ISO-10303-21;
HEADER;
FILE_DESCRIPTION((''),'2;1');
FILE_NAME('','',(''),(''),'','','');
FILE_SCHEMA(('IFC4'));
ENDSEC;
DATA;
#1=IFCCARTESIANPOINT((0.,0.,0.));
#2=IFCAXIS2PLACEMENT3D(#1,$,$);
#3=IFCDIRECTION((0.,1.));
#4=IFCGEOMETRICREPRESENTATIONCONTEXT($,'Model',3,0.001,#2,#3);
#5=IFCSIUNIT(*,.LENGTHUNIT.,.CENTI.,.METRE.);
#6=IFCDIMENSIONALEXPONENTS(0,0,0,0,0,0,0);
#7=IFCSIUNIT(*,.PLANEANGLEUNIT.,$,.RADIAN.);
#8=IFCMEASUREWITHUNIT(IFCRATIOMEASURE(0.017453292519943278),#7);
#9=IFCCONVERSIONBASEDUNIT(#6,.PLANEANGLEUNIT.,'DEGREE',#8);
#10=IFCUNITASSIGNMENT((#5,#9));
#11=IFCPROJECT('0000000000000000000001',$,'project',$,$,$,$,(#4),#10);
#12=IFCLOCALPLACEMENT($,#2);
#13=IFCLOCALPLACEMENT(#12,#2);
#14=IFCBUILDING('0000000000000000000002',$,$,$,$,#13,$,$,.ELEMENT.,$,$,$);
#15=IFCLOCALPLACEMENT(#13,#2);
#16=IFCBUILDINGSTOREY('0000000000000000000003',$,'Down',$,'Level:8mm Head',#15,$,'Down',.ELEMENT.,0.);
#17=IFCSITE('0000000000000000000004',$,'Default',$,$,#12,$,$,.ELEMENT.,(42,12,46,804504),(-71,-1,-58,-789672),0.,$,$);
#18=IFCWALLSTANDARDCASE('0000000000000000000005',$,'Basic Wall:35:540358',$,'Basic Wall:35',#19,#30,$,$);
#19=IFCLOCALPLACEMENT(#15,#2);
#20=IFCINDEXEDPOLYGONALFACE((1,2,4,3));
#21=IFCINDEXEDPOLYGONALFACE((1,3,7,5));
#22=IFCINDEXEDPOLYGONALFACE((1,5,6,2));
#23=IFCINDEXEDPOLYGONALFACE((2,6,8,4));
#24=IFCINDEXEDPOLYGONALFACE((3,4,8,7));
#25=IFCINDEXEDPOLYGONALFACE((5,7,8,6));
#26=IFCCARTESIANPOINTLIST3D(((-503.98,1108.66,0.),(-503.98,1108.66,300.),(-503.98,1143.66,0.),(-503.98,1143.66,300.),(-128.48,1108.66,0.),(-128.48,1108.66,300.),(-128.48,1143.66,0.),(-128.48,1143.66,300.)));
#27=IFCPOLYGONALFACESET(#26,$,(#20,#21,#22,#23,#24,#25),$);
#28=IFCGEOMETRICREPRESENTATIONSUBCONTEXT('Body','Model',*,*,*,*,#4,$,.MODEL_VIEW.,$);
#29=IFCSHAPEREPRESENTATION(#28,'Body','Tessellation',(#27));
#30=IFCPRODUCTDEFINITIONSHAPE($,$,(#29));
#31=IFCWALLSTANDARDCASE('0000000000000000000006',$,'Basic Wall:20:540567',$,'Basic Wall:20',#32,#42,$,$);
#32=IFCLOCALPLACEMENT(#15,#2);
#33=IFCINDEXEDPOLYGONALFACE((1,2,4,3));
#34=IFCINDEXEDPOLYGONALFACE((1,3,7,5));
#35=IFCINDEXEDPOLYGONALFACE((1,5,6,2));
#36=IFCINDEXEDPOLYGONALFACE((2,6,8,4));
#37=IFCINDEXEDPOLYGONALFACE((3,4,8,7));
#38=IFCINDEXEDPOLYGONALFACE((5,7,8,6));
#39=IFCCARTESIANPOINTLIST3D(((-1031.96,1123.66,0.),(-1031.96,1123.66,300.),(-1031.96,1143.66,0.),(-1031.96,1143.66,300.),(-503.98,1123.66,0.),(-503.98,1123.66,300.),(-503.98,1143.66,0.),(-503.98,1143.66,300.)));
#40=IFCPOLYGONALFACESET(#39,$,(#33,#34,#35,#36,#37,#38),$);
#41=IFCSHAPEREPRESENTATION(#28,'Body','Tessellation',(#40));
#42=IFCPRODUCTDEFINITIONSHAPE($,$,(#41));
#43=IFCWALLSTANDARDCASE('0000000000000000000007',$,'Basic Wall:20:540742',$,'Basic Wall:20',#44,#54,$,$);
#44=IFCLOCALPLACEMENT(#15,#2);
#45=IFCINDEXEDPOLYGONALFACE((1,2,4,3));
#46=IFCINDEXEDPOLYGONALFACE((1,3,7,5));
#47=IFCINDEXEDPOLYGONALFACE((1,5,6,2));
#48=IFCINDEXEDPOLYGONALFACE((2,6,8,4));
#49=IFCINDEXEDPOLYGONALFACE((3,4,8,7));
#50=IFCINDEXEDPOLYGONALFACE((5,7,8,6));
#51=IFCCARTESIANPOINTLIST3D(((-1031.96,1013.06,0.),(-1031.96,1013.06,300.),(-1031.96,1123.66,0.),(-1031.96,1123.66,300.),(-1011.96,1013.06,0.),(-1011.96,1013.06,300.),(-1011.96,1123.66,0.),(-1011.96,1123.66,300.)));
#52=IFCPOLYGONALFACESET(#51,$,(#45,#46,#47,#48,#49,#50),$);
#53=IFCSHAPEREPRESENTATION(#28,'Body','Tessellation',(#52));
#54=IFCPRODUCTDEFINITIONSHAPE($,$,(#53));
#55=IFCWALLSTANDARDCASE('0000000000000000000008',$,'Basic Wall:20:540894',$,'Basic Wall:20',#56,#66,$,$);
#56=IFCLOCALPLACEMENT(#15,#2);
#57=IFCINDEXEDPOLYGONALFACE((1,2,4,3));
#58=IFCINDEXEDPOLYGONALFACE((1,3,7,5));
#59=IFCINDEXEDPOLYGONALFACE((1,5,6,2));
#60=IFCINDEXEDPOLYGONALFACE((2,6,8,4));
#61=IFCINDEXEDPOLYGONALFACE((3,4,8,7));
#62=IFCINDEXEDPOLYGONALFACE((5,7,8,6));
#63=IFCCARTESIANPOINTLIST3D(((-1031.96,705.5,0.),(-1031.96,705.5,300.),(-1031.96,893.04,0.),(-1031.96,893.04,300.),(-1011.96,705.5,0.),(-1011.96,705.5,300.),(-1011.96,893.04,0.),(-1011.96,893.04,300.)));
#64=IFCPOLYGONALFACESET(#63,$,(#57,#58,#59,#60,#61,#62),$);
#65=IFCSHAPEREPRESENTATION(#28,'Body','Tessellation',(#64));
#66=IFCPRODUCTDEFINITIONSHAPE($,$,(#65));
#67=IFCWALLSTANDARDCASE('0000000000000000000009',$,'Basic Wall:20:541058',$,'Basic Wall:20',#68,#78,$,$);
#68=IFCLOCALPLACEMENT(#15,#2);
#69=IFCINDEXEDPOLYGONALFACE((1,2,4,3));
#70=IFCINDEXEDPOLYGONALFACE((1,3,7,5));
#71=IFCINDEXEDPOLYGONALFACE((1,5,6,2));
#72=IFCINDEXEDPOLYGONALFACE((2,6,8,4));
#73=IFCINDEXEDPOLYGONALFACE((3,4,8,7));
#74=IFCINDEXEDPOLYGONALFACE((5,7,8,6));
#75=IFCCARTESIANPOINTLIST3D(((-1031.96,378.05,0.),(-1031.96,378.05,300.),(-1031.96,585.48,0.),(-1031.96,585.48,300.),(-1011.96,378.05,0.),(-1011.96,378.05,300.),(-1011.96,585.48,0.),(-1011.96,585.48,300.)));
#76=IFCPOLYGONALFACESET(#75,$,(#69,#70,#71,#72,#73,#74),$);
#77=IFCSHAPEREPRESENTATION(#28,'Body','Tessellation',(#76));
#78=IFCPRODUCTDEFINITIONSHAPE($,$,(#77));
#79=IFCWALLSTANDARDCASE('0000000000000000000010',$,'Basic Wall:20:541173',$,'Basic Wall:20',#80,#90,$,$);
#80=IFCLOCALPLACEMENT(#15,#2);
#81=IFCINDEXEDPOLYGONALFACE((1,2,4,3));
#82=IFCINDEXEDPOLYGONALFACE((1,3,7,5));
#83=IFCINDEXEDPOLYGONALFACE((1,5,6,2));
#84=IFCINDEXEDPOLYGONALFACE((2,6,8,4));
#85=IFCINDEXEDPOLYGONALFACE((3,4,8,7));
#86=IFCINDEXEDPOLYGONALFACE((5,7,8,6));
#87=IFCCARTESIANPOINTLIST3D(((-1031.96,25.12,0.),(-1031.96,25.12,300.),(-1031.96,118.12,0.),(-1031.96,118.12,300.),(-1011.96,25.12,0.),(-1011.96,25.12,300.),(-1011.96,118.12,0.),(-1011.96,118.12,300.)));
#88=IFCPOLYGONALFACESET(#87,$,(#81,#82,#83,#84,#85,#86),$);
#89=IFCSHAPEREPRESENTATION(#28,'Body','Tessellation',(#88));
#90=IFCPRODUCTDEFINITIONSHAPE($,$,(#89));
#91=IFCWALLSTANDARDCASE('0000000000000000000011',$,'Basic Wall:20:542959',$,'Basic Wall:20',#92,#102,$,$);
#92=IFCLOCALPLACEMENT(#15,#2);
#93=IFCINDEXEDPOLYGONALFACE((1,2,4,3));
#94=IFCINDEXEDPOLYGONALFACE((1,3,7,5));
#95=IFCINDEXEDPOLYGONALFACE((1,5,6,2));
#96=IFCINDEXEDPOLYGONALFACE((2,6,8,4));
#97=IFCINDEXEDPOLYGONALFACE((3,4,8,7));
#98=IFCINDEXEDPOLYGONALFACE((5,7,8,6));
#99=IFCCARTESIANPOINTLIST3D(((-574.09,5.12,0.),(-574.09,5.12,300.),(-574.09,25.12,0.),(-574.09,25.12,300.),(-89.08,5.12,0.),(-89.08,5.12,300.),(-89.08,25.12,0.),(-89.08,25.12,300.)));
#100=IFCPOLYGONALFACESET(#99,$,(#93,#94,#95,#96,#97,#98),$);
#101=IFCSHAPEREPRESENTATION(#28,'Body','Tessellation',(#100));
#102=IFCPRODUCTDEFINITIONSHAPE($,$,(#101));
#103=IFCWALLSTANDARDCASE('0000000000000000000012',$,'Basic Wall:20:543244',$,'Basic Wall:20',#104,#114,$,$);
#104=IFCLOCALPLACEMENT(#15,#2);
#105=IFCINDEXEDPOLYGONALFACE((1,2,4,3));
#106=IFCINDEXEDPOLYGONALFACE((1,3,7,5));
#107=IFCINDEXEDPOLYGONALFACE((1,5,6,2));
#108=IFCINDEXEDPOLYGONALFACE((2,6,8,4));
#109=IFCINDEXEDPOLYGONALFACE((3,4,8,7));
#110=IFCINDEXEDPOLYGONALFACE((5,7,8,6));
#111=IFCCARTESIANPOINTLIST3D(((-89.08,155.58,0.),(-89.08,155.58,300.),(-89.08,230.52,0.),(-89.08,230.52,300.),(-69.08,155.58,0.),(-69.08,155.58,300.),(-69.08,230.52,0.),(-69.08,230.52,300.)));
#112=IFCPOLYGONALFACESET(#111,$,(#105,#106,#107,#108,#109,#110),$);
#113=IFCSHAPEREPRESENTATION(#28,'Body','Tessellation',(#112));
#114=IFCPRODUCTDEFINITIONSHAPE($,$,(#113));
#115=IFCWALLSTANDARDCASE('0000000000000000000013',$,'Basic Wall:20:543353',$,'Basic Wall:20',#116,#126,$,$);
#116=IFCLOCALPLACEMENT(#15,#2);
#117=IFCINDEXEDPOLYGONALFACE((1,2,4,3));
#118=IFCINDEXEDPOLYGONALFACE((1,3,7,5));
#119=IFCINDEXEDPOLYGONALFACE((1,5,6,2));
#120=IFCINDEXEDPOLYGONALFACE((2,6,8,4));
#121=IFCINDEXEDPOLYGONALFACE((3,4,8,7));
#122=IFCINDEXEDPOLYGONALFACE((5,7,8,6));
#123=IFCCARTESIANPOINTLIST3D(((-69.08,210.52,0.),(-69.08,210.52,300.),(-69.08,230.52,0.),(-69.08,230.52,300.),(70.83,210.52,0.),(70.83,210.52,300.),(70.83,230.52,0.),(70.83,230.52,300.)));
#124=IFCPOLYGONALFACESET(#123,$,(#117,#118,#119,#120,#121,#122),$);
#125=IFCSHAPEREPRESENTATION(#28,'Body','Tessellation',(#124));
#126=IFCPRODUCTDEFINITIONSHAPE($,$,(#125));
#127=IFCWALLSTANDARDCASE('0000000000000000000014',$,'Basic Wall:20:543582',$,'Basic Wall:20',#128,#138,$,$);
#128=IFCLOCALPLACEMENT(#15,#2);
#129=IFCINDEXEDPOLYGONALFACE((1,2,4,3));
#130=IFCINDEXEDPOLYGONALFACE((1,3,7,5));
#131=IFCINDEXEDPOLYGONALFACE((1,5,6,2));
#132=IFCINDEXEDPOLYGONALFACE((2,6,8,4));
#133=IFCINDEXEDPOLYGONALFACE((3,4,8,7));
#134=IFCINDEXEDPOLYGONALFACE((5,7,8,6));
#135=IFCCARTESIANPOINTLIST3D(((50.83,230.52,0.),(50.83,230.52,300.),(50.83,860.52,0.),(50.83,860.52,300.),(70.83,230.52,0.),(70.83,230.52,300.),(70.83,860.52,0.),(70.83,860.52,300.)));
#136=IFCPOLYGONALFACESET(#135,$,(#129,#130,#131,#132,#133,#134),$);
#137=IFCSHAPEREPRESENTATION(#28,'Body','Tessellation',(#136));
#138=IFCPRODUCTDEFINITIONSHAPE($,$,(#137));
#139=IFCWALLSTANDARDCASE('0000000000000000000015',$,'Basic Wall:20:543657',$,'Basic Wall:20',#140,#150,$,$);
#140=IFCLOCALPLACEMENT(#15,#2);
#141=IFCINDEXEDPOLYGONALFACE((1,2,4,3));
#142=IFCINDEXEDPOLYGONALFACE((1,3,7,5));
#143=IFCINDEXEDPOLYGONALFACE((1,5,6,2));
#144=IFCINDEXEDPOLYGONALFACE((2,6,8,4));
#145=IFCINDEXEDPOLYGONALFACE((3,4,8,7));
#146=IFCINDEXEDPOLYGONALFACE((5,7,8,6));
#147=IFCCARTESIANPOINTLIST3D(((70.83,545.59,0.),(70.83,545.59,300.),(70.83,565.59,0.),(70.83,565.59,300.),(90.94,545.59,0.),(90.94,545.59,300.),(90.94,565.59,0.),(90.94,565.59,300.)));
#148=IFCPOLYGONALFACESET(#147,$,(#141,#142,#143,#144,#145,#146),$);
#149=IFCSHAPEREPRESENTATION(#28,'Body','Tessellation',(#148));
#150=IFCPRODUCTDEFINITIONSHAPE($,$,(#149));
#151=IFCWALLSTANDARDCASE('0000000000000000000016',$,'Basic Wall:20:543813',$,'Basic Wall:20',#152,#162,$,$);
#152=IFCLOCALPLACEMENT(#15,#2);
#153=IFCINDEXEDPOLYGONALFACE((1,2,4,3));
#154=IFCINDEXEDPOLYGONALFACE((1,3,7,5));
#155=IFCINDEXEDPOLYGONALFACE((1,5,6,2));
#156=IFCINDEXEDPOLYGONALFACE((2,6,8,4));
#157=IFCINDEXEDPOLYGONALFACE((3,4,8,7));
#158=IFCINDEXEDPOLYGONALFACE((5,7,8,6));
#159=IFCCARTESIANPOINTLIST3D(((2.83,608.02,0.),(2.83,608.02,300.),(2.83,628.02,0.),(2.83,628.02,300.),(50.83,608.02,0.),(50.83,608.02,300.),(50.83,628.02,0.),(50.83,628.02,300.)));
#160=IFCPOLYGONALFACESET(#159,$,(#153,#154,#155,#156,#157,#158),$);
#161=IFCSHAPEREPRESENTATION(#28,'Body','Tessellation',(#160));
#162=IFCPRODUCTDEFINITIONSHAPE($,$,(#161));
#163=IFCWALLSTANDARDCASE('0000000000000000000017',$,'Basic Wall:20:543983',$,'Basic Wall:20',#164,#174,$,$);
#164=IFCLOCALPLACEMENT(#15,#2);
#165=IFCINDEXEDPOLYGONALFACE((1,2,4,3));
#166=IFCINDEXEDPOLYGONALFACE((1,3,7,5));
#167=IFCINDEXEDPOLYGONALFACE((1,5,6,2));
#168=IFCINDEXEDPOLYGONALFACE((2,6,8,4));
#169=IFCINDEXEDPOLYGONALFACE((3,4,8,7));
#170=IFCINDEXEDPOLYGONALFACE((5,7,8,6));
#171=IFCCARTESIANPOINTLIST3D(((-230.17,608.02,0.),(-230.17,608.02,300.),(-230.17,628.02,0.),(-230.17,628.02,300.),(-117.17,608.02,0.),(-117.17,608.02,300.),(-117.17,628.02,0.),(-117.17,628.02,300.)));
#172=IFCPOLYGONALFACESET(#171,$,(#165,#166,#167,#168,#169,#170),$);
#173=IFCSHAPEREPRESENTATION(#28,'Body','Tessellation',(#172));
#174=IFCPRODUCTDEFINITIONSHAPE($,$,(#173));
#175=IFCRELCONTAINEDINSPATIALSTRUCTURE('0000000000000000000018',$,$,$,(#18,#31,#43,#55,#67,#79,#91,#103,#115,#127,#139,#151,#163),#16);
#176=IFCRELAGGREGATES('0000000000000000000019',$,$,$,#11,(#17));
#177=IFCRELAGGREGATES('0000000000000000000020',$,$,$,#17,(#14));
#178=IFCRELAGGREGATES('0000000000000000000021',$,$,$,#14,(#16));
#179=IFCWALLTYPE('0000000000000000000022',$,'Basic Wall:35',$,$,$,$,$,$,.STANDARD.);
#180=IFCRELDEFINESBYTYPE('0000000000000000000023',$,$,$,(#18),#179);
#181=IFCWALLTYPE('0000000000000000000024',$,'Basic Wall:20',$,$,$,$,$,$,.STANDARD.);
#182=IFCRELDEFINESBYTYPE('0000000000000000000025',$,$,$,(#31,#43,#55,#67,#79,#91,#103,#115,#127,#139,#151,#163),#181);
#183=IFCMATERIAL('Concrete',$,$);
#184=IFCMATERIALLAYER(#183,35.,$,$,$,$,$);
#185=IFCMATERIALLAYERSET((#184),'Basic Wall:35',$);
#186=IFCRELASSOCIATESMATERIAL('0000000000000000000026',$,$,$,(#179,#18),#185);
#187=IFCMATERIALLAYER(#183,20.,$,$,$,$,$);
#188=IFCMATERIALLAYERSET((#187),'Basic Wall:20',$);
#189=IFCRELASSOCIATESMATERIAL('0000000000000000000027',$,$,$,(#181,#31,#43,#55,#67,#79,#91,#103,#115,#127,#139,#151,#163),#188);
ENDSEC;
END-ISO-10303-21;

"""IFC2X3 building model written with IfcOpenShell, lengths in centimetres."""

from ifc_helpers import new_model, entity, si_unit, converted_unit, direction, frame, frame_2d, origin, place, context, subcontext, project, spatial, rectangle, extrude, material, layer, layer_set, layer_usage, type_object, element, save


model = new_model("IFC2X3")

# Units and contexts
model_context = context("Model", 3, precision=0.001, world=origin(), true_north=direction((0.0, 1.0)))
body_context = subcontext(model_context, "Body", "Model", "MODEL_VIEW")
ifc_project = project(units=[si_unit("LENGTHUNIT", "METRE", prefix="CENTI"), converted_unit("PLANEANGLEUNIT", "DEGREE", entity("IfcRatioMeasure", 0.017453292519943278), si_unit("PLANEANGLEUNIT", "RADIAN"), dimensions=[0, 0, 0, 0, 0, 0, 0])], contexts=[model_context])

# Site, building, storey
site_placement = place(None, origin())
site = spatial("IfcSite", under=ifc_project, at=site_placement, Name="Default", CompositionType="ELEMENT", RefLatitude=(42, 12, 46, 804504), RefLongitude=(-71, -1, -58, -789672), RefElevation=0.0)
building_placement = place(site_placement, origin())
building = spatial("IfcBuilding", under=site, at=building_placement, CompositionType="ELEMENT")
storey_placement = place(building_placement, origin())
storey = spatial("IfcBuildingStorey", under=building, at=storey_placement, Name="Down", ObjectType="Level:8mm Head", LongName="Down", CompositionType="ELEMENT", Elevation=0.0)

# Walls
ifc_material = material(Name="Concrete")
ifc_layer_1 = layer(ifc_material, 35.0)
ifc_layer_set_1 = layer_set([ifc_layer_1], Name="Basic Wall:35")
ifc_layer_usage_1 = layer_usage(ifc_layer_set_1, "AXIS2", "POSITIVE", -17.5)
wall_type_1 = type_object("IfcWallType", Name="Basic Wall:35", PredefinedType="STANDARD", material=ifc_layer_set_1)
wall_1_placement = place(storey_placement, frame((-128.48, 1126.16, 0.0), z_axis=(0.0, 0.0, 1.0), x_axis=(-1.0, 0.0, 0.0)))
element("IfcWallStandardCase", 1, at=wall_1_placement, inside=storey, type_object=wall_type_1, material=ifc_layer_usage_1, Name="Basic Wall:35:540358", ObjectType="Basic Wall:35", context=body_context, shape_type="SweptSolid", body=[
    extrude(rectangle(XDim=375.5, YDim=35.0, at=frame_2d((187.75, 0.0), x_axis=(-1.0, 0.0))), origin(), (0.0, 0.0, 1.0), 300.0),
])
ifc_layer_2 = layer(ifc_material, 20.0)
ifc_layer_set_2 = layer_set([ifc_layer_2], Name="Basic Wall:20")
ifc_layer_usage_2 = layer_usage(ifc_layer_set_2, "AXIS2", "POSITIVE", -10.0)
wall_type_2 = type_object("IfcWallType", Name="Basic Wall:20", PredefinedType="STANDARD", material=ifc_layer_set_2)
wall_2_placement = place(storey_placement, frame((-503.98, 1133.66, 0.0), z_axis=(0.0, 0.0, 1.0), x_axis=(-1.0, 0.0, 0.0)))
element("IfcWallStandardCase", 2, at=wall_2_placement, inside=storey, type_object=wall_type_2, material=ifc_layer_usage_2, Name="Basic Wall:20:540567", ObjectType="Basic Wall:20", context=body_context, shape_type="SweptSolid", body=[
    extrude(rectangle(XDim=527.98, YDim=20.0, at=frame_2d((263.99, 0.0), x_axis=(-1.0, 0.0))), origin(), (0.0, 0.0, 1.0), 300.0),
])
ifc_layer_usage_3 = layer_usage(ifc_layer_set_2, "AXIS2", "POSITIVE", -10.0)
wall_3_placement = place(storey_placement, frame((-1021.96, 1123.66, 0.0), z_axis=(0.0, 0.0, 1.0), x_axis=(0.0, -1.0, 0.0)))
element("IfcWallStandardCase", 3, at=wall_3_placement, inside=storey, type_object=wall_type_2, material=ifc_layer_usage_3, Name="Basic Wall:20:540742", ObjectType="Basic Wall:20", context=body_context, shape_type="SweptSolid", body=[
    extrude(rectangle(XDim=110.6, YDim=20.0, at=frame_2d((55.3, 0.0), x_axis=(-1.0, 0.0))), origin(), (0.0, 0.0, 1.0), 300.0),
])
ifc_layer_usage_4 = layer_usage(ifc_layer_set_2, "AXIS2", "POSITIVE", -10.0)
wall_4_placement = place(storey_placement, frame((-1021.96, 893.04, 0.0), z_axis=(0.0, 0.0, 1.0), x_axis=(0.0, -1.0, 0.0)))
element("IfcWallStandardCase", 4, at=wall_4_placement, inside=storey, type_object=wall_type_2, material=ifc_layer_usage_4, Name="Basic Wall:20:540894", ObjectType="Basic Wall:20", context=body_context, shape_type="SweptSolid", body=[
    extrude(rectangle(XDim=187.54, YDim=20.0, at=frame_2d((93.77, 0.0), x_axis=(-1.0, 0.0))), origin(), (0.0, 0.0, 1.0), 300.0),
])
ifc_layer_usage_5 = layer_usage(ifc_layer_set_2, "AXIS2", "POSITIVE", -10.0)
wall_5_placement = place(storey_placement, frame((-1021.96, 585.48, 0.0), z_axis=(0.0, 0.0, 1.0), x_axis=(0.0, -1.0, 0.0)))
element("IfcWallStandardCase", 5, at=wall_5_placement, inside=storey, type_object=wall_type_2, material=ifc_layer_usage_5, Name="Basic Wall:20:541058", ObjectType="Basic Wall:20", context=body_context, shape_type="SweptSolid", body=[
    extrude(rectangle(XDim=207.44, YDim=20.0, at=frame_2d((103.72, 0.0), x_axis=(-1.0, 0.0))), origin(), (0.0, 0.0, 1.0), 300.0),
])
ifc_layer_usage_6 = layer_usage(ifc_layer_set_2, "AXIS2", "POSITIVE", -10.0)
wall_6_placement = place(storey_placement, frame((-1021.96, 118.12, 0.0), z_axis=(0.0, 0.0, 1.0), x_axis=(0.0, -1.0, 0.0)))
element("IfcWallStandardCase", 6, at=wall_6_placement, inside=storey, type_object=wall_type_2, material=ifc_layer_usage_6, Name="Basic Wall:20:541173", ObjectType="Basic Wall:20", context=body_context, shape_type="SweptSolid", body=[
    extrude(rectangle(XDim=93.0, YDim=20.0, at=frame_2d((46.5, 0.0), x_axis=(-1.0, 0.0))), origin(), (0.0, 0.0, 1.0), 300.0),
])
ifc_layer_usage_7 = layer_usage(ifc_layer_set_2, "AXIS2", "NEGATIVE", 10.0)
wall_7_placement = place(storey_placement, frame((-574.09, 15.12, 0.0)))
element("IfcWallStandardCase", 7, at=wall_7_placement, inside=storey, type_object=wall_type_2, material=ifc_layer_usage_7, Name="Basic Wall:20:542959", ObjectType="Basic Wall:20", context=body_context, shape_type="SweptSolid", body=[
    extrude(rectangle(XDim=485.01, YDim=20.0, at=frame_2d((242.51, 0.0), x_axis=(-1.0, 0.0))), origin(), (0.0, 0.0, 1.0), 300.0),
])
ifc_layer_usage_8 = layer_usage(ifc_layer_set_2, "AXIS2", "POSITIVE", -10.0)
wall_8_placement = place(storey_placement, frame((-79.08, 155.58, 0.0), z_axis=(0.0, 0.0, 1.0), x_axis=(0.0, 1.0, 0.0)))
element("IfcWallStandardCase", 8, at=wall_8_placement, inside=storey, type_object=wall_type_2, material=ifc_layer_usage_8, Name="Basic Wall:20:543244", ObjectType="Basic Wall:20", context=body_context, shape_type="SweptSolid", body=[
    extrude(rectangle(XDim=74.93, YDim=20.0, at=frame_2d((37.47, 0.0), x_axis=(-1.0, 0.0))), origin(), (0.0, 0.0, 1.0), 300.0),
])
ifc_layer_usage_9 = layer_usage(ifc_layer_set_2, "AXIS2", "NEGATIVE", 10.0)
wall_9_placement = place(storey_placement, frame((-69.08, 220.52, 0.0)))
element("IfcWallStandardCase", 9, at=wall_9_placement, inside=storey, type_object=wall_type_2, material=ifc_layer_usage_9, Name="Basic Wall:20:543353", ObjectType="Basic Wall:20", context=body_context, shape_type="SweptSolid", body=[
    extrude(rectangle(XDim=139.91, YDim=20.0, at=frame_2d((69.96, 0.0), x_axis=(-1.0, 0.0))), origin(), (0.0, 0.0, 1.0), 300.0),
])
ifc_layer_usage_10 = layer_usage(ifc_layer_set_2, "AXIS2", "POSITIVE", -10.0)
wall_10_placement = place(storey_placement, frame((60.83, 230.52, 0.0), z_axis=(0.0, 0.0, 1.0), x_axis=(0.0, 1.0, 0.0)))
element("IfcWallStandardCase", 10, at=wall_10_placement, inside=storey, type_object=wall_type_2, material=ifc_layer_usage_10, Name="Basic Wall:20:543582", ObjectType="Basic Wall:20", context=body_context, shape_type="SweptSolid", body=[
    extrude(rectangle(XDim=630.0, YDim=20.0, at=frame_2d((315.0, 0.0), x_axis=(-1.0, 0.0))), origin(), (0.0, 0.0, 1.0), 300.0),
])
ifc_layer_usage_11 = layer_usage(ifc_layer_set_2, "AXIS2", "NEGATIVE", 10.0)
wall_11_placement = place(storey_placement, frame((70.83, 555.59, 0.0)))
element("IfcWallStandardCase", 11, at=wall_11_placement, inside=storey, type_object=wall_type_2, material=ifc_layer_usage_11, Name="Basic Wall:20:543657", ObjectType="Basic Wall:20", context=body_context, shape_type="SweptSolid", body=[
    extrude(rectangle(XDim=20.11, YDim=20.0, at=frame_2d((10.05, 0.0), x_axis=(-1.0, 0.0))), origin(), (0.0, 0.0, 1.0), 300.0),
])
ifc_layer_usage_12 = layer_usage(ifc_layer_set_2, "AXIS2", "NEGATIVE", 10.0)
wall_12_placement = place(storey_placement, frame((50.83, 618.02, 0.0), z_axis=(0.0, 0.0, 1.0), x_axis=(-1.0, 0.0, 0.0)))
element("IfcWallStandardCase", 12, at=wall_12_placement, inside=storey, type_object=wall_type_2, material=ifc_layer_usage_12, Name="Basic Wall:20:543813", ObjectType="Basic Wall:20", context=body_context, shape_type="SweptSolid", body=[
    extrude(rectangle(XDim=48.0, YDim=20.0, at=frame_2d((24.0, 0.0), x_axis=(-1.0, 0.0))), origin(), (0.0, 0.0, 1.0), 300.0),
])
ifc_layer_usage_13 = layer_usage(ifc_layer_set_2, "AXIS2", "NEGATIVE", 10.0)
wall_13_placement = place(storey_placement, frame((-117.17, 618.02, 0.0), z_axis=(0.0, 0.0, 1.0), x_axis=(-1.0, 0.0, 0.0)))
element("IfcWallStandardCase", 13, at=wall_13_placement, inside=storey, type_object=wall_type_2, material=ifc_layer_usage_13, Name="Basic Wall:20:543983", ObjectType="Basic Wall:20", context=body_context, shape_type="SweptSolid", body=[
    extrude(rectangle(XDim=113.0, YDim=20.0, at=frame_2d((56.5, 0.0), x_axis=(-1.0, 0.0))), origin(), (0.0, 0.0, 1.0), 300.0),
])

save(model, "model.ifc")
